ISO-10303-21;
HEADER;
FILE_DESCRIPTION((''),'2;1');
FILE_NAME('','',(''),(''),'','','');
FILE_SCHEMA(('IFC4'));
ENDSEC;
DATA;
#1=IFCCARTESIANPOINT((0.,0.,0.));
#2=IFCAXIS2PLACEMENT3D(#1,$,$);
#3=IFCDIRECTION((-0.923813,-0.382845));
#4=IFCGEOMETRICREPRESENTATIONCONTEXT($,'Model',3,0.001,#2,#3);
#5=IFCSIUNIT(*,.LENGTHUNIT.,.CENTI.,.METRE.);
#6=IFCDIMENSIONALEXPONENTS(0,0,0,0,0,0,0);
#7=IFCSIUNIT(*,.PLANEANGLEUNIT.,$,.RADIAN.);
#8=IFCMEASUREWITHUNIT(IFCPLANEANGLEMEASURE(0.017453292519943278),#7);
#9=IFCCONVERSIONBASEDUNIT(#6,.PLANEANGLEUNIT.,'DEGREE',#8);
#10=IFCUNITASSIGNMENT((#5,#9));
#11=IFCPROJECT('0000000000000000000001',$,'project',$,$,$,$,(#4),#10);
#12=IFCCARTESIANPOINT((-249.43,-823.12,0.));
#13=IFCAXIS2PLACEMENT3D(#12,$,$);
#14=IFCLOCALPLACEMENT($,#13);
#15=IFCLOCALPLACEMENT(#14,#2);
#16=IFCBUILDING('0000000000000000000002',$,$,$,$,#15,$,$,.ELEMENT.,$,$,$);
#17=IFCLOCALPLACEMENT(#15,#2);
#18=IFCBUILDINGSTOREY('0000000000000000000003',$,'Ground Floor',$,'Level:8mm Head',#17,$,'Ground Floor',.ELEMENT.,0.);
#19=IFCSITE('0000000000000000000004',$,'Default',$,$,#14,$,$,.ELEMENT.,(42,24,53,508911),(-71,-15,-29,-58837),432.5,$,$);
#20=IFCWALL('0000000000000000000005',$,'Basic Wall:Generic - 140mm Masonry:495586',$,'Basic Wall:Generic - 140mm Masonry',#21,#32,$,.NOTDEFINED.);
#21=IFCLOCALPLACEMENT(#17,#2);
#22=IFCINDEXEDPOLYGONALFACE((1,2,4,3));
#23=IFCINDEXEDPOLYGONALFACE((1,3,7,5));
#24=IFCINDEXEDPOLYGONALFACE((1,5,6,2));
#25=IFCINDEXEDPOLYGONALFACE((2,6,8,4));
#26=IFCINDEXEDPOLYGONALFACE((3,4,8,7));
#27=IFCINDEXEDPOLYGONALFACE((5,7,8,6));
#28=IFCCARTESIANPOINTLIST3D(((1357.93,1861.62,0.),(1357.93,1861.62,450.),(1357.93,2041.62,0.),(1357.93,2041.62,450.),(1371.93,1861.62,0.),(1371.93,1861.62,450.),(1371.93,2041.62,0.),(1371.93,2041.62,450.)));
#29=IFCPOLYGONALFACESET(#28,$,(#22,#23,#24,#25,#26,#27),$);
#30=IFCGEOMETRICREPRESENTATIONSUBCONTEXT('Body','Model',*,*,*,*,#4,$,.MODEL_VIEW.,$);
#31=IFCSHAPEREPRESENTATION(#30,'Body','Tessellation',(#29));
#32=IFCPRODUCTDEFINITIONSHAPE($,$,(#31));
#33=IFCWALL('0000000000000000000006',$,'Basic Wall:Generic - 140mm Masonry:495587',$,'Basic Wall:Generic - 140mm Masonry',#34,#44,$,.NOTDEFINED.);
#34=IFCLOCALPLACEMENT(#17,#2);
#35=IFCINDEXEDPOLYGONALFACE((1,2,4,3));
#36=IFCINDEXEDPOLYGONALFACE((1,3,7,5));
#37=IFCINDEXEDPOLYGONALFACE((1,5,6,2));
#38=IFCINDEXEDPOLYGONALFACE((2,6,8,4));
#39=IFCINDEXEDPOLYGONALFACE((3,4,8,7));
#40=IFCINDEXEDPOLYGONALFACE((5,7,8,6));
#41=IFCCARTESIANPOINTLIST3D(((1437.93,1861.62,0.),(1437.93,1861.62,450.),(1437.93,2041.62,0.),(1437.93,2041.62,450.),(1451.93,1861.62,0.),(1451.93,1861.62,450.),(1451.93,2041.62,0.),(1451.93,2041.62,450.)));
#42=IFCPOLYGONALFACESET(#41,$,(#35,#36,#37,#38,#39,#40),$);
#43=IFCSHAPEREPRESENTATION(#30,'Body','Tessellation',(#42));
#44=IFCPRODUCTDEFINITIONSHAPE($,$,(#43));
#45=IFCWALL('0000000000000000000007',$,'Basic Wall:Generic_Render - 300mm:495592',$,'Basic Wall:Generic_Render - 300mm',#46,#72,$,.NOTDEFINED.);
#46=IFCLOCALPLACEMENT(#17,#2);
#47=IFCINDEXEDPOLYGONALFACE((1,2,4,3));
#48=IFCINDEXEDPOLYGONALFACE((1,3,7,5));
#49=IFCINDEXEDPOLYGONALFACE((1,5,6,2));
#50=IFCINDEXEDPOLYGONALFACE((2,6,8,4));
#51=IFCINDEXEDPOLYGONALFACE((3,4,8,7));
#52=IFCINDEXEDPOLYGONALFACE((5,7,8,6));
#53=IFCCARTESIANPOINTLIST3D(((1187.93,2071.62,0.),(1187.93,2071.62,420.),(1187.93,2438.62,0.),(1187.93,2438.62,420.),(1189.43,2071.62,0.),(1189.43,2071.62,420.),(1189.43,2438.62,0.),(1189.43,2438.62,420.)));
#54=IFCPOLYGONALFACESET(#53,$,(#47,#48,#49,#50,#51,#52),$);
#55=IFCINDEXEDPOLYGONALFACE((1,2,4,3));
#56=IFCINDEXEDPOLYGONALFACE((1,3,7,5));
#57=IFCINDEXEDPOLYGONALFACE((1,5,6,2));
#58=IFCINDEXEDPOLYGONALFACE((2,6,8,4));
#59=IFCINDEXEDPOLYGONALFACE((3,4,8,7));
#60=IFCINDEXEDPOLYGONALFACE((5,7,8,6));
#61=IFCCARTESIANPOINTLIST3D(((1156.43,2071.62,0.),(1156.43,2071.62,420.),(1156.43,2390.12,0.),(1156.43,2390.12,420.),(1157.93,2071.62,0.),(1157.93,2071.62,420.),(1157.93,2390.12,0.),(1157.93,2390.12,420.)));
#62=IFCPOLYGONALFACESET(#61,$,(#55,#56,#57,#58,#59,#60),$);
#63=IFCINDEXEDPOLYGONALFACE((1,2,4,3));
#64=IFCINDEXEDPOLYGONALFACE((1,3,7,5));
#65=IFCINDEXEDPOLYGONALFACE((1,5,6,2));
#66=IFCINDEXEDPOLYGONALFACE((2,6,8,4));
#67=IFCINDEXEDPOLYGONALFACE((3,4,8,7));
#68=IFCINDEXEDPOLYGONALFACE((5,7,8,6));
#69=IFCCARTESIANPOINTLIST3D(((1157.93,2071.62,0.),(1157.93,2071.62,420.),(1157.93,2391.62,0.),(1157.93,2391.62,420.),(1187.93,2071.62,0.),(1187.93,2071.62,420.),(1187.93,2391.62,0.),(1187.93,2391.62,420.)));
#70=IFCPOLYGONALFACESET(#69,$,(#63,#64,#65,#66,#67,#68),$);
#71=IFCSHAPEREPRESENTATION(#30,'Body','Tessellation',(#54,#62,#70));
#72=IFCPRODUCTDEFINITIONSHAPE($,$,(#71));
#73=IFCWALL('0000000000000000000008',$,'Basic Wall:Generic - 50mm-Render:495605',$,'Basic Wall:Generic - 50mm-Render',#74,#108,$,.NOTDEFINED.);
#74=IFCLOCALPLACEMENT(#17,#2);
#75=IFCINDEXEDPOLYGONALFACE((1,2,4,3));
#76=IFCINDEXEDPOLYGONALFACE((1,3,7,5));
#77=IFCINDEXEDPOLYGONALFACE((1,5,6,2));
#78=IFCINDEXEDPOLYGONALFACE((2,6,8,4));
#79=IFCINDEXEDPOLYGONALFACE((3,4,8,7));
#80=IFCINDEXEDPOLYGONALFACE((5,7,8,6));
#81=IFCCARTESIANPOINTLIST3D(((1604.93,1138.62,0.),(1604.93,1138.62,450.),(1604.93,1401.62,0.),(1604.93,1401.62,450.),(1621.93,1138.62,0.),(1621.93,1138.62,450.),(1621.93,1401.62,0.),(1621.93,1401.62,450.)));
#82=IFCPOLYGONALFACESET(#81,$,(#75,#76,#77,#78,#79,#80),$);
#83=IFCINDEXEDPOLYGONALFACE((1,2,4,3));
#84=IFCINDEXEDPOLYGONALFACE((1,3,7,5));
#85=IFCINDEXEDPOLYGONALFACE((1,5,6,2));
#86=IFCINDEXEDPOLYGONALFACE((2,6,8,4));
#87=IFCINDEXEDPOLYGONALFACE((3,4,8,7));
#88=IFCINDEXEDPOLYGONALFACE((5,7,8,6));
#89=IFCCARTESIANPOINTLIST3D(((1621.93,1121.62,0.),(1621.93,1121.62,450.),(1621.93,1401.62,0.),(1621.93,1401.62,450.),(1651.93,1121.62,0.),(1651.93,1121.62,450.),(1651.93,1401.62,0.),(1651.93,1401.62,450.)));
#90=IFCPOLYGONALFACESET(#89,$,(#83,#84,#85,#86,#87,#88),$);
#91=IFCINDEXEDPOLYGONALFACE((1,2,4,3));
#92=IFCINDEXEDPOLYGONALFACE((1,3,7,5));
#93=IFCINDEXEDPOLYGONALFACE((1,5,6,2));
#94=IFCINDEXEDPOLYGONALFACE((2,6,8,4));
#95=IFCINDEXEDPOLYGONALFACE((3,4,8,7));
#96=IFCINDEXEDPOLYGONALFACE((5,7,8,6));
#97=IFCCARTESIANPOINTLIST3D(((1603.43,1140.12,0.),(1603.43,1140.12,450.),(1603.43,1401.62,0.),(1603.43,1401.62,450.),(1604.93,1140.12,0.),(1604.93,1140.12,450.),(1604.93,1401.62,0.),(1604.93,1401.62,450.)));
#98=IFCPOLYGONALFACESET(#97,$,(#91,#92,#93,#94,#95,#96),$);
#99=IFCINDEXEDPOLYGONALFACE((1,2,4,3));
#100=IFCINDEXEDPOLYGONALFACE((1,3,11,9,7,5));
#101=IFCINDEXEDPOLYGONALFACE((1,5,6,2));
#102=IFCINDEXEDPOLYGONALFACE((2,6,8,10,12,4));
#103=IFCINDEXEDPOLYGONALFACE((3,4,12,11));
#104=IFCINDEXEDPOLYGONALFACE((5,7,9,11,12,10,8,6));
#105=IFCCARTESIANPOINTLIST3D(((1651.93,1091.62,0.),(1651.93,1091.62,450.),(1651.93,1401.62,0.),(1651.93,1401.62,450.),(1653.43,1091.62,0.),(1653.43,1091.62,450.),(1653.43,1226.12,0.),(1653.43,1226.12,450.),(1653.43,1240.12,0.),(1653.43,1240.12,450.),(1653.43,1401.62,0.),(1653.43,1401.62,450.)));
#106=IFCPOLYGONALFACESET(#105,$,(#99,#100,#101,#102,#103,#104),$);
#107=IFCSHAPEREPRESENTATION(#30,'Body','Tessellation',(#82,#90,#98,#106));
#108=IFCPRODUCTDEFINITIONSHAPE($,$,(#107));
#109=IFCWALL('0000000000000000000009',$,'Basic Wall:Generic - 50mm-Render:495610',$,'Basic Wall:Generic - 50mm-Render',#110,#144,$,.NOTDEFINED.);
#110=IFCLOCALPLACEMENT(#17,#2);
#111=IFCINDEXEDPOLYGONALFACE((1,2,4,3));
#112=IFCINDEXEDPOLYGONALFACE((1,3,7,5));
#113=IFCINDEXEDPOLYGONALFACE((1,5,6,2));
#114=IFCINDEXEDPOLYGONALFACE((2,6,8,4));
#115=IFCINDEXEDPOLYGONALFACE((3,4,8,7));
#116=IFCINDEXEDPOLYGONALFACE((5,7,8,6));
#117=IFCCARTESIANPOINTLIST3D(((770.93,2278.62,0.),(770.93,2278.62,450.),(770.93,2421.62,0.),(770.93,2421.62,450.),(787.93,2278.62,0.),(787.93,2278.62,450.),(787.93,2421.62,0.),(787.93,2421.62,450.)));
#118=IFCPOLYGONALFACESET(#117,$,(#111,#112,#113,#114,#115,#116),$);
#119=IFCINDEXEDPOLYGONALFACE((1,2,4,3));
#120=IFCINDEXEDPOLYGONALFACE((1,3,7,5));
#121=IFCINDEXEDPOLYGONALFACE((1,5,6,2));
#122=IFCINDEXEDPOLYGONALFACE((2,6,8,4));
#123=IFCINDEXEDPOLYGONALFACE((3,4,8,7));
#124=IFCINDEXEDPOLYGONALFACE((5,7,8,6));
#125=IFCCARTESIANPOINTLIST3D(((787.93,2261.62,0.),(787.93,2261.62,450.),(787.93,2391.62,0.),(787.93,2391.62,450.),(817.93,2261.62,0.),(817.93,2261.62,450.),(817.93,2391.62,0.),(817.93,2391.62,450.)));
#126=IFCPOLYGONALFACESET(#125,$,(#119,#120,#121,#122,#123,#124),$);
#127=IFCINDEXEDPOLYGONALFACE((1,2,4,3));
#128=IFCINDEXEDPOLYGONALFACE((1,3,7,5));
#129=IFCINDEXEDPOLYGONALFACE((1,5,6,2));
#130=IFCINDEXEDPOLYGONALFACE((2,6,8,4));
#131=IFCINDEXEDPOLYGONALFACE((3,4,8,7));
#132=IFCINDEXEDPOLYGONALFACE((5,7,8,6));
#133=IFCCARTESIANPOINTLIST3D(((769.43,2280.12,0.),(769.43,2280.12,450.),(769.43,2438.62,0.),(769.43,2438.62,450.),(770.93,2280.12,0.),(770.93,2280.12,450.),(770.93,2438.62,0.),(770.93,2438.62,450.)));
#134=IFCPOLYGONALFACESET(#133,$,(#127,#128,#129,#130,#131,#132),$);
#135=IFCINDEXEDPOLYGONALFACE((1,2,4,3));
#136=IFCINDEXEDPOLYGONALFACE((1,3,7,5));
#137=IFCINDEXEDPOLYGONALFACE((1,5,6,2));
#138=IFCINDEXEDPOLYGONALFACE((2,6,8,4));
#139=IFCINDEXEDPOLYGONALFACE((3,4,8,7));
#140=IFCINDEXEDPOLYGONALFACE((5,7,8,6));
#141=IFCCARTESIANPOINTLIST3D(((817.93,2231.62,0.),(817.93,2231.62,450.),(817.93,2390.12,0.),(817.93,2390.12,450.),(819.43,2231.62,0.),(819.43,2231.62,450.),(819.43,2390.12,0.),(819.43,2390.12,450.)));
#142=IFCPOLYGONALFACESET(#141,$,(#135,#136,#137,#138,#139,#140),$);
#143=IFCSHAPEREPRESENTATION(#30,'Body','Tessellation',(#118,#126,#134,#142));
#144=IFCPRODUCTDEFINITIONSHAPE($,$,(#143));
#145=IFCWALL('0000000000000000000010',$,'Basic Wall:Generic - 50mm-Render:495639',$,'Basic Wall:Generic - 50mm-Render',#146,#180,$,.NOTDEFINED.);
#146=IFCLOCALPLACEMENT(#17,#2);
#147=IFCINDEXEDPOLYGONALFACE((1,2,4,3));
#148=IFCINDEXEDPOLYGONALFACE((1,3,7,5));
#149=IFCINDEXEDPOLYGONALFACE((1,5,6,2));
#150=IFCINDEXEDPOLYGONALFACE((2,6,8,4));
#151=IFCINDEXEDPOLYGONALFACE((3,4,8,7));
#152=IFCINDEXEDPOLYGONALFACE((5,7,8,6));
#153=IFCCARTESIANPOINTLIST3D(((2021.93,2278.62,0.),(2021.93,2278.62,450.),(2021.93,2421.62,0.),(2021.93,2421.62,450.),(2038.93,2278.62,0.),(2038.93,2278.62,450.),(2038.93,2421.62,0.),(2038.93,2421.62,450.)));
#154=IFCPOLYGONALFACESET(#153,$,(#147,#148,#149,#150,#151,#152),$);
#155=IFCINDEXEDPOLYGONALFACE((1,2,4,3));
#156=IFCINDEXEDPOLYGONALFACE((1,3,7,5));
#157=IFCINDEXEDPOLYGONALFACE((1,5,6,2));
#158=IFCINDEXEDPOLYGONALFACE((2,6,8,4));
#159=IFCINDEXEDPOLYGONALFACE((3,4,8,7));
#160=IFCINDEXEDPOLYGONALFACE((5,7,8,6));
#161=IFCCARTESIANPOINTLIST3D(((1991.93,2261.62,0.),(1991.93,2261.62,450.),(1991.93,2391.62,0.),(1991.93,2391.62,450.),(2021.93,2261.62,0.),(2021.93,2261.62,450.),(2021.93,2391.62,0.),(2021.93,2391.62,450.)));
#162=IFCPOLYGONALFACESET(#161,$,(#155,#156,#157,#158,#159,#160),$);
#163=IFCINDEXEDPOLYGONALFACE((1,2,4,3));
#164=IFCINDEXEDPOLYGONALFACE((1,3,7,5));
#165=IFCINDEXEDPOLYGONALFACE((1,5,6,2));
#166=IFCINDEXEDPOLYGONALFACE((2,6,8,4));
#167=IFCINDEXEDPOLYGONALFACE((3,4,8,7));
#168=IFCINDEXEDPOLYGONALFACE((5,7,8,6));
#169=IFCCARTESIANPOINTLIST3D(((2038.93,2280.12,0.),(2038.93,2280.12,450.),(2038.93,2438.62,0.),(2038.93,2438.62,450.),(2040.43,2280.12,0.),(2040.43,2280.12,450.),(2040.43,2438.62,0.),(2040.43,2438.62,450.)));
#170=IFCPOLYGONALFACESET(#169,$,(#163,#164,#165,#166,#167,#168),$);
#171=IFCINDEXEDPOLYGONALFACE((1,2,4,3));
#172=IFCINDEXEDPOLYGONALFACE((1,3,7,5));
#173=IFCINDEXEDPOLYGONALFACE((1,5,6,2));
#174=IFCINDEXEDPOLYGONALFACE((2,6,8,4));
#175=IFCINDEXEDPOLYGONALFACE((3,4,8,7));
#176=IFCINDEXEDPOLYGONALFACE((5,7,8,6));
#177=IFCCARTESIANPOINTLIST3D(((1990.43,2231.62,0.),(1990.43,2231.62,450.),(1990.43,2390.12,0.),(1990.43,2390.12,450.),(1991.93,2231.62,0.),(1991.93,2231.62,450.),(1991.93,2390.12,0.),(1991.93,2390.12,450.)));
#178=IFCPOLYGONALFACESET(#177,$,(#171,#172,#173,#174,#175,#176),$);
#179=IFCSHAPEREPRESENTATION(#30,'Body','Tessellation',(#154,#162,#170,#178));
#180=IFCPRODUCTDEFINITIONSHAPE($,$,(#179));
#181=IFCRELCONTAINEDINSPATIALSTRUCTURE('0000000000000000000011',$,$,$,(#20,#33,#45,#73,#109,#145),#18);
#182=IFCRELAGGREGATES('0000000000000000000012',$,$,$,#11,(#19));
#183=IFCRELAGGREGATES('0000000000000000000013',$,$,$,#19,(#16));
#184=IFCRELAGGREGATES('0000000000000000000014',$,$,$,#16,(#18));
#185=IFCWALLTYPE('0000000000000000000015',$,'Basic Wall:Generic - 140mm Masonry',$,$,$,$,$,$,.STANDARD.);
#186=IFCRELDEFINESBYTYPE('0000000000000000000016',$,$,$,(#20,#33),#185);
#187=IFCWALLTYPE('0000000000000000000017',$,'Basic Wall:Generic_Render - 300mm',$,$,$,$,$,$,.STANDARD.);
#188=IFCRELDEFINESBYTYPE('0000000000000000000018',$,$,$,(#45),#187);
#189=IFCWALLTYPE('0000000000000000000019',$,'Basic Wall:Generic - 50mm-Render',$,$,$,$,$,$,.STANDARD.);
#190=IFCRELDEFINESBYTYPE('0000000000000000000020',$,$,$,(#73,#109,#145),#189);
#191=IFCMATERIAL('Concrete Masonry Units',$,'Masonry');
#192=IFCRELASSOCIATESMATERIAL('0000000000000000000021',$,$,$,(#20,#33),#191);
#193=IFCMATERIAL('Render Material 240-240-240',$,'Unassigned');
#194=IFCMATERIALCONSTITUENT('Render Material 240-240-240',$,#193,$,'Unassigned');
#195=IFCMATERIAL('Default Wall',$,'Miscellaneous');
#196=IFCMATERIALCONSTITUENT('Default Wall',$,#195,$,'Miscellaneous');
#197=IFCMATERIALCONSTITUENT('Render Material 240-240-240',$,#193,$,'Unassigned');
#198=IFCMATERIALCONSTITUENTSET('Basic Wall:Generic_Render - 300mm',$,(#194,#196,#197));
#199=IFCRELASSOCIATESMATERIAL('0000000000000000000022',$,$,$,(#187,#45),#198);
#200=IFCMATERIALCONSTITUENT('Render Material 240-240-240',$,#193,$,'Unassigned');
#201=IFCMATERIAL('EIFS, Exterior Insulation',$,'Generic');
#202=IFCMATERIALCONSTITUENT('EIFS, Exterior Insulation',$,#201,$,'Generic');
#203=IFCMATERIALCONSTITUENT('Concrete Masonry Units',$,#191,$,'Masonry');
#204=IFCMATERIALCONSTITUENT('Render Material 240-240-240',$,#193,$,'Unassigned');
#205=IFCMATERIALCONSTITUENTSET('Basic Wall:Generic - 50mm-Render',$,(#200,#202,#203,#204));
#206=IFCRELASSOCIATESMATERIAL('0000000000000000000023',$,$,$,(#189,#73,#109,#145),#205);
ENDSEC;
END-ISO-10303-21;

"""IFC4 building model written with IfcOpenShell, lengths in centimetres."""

from ifc_helpers import new_model, entity, si_unit, converted_unit, direction, frame, origin, place, context, subcontext, project, spatial, indexed_curve, outline, extrude, material, constituent, constituent_set, type_object, element, save


model = new_model("IFC4")

# Units and contexts
model_context = context("Model", 3, precision=0.001, world=origin(), true_north=direction((-0.923813, -0.382845)))
body_context = subcontext(model_context, "Body", "Model", "MODEL_VIEW")
ifc_project = project(units=[si_unit("LENGTHUNIT", "METRE", prefix="CENTI"), converted_unit("PLANEANGLEUNIT", "DEGREE", entity("IfcPlaneAngleMeasure", 0.017453292519943278), si_unit("PLANEANGLEUNIT", "RADIAN"), dimensions=[0, 0, 0, 0, 0, 0, 0])], contexts=[model_context])

# Site, building, storey
site_placement = place(None, frame((-249.43, -823.12, 0.0)))
site = spatial("IfcSite", under=ifc_project, at=site_placement, Name="Default", CompositionType="ELEMENT", RefLatitude=(42, 24, 53, 508911), RefLongitude=(-71, -15, -29, -58837), RefElevation=432.5)
building_placement = place(site_placement, origin())
building = spatial("IfcBuilding", under=site, at=building_placement, CompositionType="ELEMENT")
storey_placement = place(building_placement, origin())
storey = spatial("IfcBuildingStorey", under=building, at=storey_placement, Name="Ground Floor", ObjectType="Level:8mm Head", LongName="Ground Floor", CompositionType="ELEMENT", Elevation=0.0)

# Walls
ifc_material_1 = material(Name="Concrete Masonry Units", Category="Masonry")
wall_type_1 = type_object("IfcWallType", Name="Basic Wall:Generic - 140mm Masonry", PredefinedType="STANDARD")
wall_1_placement = place(storey_placement, frame((1364.93, 2041.62, 0.0), z_axis=(0.0, 0.0, 1.0), x_axis=(0.0, -1.0, 0.0)))
element("IfcWall", 1, at=wall_1_placement, inside=storey, type_object=wall_type_1, material=ifc_material_1, Name="Basic Wall:Generic - 140mm Masonry:495586", ObjectType="Basic Wall:Generic - 140mm Masonry", PredefinedType="NOTDEFINED", context=body_context, shape_type="SweptSolid", body=[
    extrude(outline(indexed_curve([(180.0, 7.0), (0.0, 7.0), (0.0, -7.0), (180.0, -7.0), (180.0, 7.0)], self_intersect=False)), origin(), (0.0, 0.0, 1.0), 450.0),
])
wall_2_placement = place(storey_placement, frame((1444.93, 2041.62, 0.0), z_axis=(0.0, 0.0, 1.0), x_axis=(0.0, -1.0, 0.0)))
element("IfcWall", 2, at=wall_2_placement, inside=storey, type_object=wall_type_1, material=ifc_material_1, Name="Basic Wall:Generic - 140mm Masonry:495587", ObjectType="Basic Wall:Generic - 140mm Masonry", PredefinedType="NOTDEFINED", context=body_context, shape_type="SweptSolid", body=[
    extrude(outline(indexed_curve([(180.0, 7.0), (0.0, 7.0), (0.0, -7.0), (180.0, -7.0), (180.0, 7.0)], self_intersect=False)), origin(), (0.0, 0.0, 1.0), 450.0),
])
ifc_material_2 = material(Name="Render Material 240-240-240", Category="Unassigned")
ifc_constituent_1 = constituent(ifc_material_2, Name="Render Material 240-240-240", Category="Unassigned")
ifc_material_3 = material(Name="Default Wall", Category="Miscellaneous")
ifc_constituent_2 = constituent(ifc_material_3, Name="Default Wall", Category="Miscellaneous")
ifc_constituent_3 = constituent(ifc_material_2, Name="Render Material 240-240-240", Category="Unassigned")
ifc_constituent_set_1 = constituent_set(constituents=[ifc_constituent_1, ifc_constituent_2, ifc_constituent_3], Name="Basic Wall:Generic_Render - 300mm")
wall_type_2 = type_object("IfcWallType", Name="Basic Wall:Generic_Render - 300mm", PredefinedType="STANDARD", material=ifc_constituent_set_1)
wall_3_placement = place(storey_placement, frame((1172.93, 2071.62, 0.0), z_axis=(0.0, 0.0, 1.0), x_axis=(0.0, 1.0, 0.0)))
element("IfcWall", 3, at=wall_3_placement, inside=storey, type_object=wall_type_2, material=ifc_constituent_set_1, Name="Basic Wall:Generic_Render - 300mm:495592", ObjectType="Basic Wall:Generic_Render - 300mm", PredefinedType="NOTDEFINED", context=body_context, shape_type="SweptSolid", body=[
    extrude(outline(indexed_curve([(-0.75, -183.5), (0.75, -183.5), (0.75, 183.5), (-0.75, 183.5), (-0.75, -183.5)], self_intersect=False)), frame((183.5, -15.75, 0.0), z_axis=(0.0, 0.0, 1.0), x_axis=(0.0, 1.0, 0.0)), (0.0, 0.0, 1.0), 420.0),
    extrude(outline(indexed_curve([(-0.75, -159.25), (0.75, -159.25), (0.75, 159.25), (-0.75, 159.25), (-0.75, -159.25)], self_intersect=False)), frame((159.25, 15.75, 0.0), z_axis=(0.0, 0.0, 1.0), x_axis=(0.0, -1.0, 0.0)), (0.0, 0.0, 1.0), 420.0),
    extrude(outline(indexed_curve([(-160.0, -15.0), (160.0, -15.0), (160.0, 15.0), (-160.0, 15.0), (-160.0, -15.0)], self_intersect=False)), frame((160.0, 0.0, 0.0)), (0.0, 0.0, 1.0), 420.0),
])
ifc_constituent_4 = constituent(ifc_material_2, Name="Render Material 240-240-240", Category="Unassigned")
ifc_material_4 = material(Name="EIFS, Exterior Insulation", Category="Generic")
ifc_constituent_5 = constituent(ifc_material_4, Name="EIFS, Exterior Insulation", Category="Generic")
ifc_constituent_6 = constituent(ifc_material_1, Name="Concrete Masonry Units", Category="Masonry")
ifc_constituent_7 = constituent(ifc_material_2, Name="Render Material 240-240-240", Category="Unassigned")
ifc_constituent_set_2 = constituent_set(constituents=[ifc_constituent_4, ifc_constituent_5, ifc_constituent_6, ifc_constituent_7], Name="Basic Wall:Generic - 50mm-Render")
wall_type_3 = type_object("IfcWallType", Name="Basic Wall:Generic - 50mm-Render", PredefinedType="STANDARD", material=ifc_constituent_set_2)
wall_4_placement = place(storey_placement, frame((1628.43, 1401.62, 0.0), z_axis=(0.0, 0.0, 1.0), x_axis=(0.0, -1.0, 0.0)))
element("IfcWall", 4, at=wall_4_placement, inside=storey, type_object=wall_type_3, material=ifc_constituent_set_2, Name="Basic Wall:Generic - 50mm-Render:495605", ObjectType="Basic Wall:Generic - 50mm-Render", PredefinedType="NOTDEFINED", context=body_context, shape_type="SweptSolid", body=[
    extrude(outline(indexed_curve([(-131.5, -8.5), (131.5, -8.5), (131.5, 8.5), (-131.5, 8.5), (-131.5, -8.5)], self_intersect=False)), frame((131.5, -15.0, 0.0)), (0.0, 0.0, 1.0), 450.0),
    extrude(outline(indexed_curve([(-140.0, -15.0), (140.0, -15.0), (140.0, 15.0), (-140.0, 15.0), (-140.0, -15.0)], self_intersect=False)), frame((140.0, 8.5, 0.0)), (0.0, 0.0, 1.0), 450.0),
    extrude(outline(indexed_curve([(-0.75, -130.75), (0.75, -130.75), (0.75, 130.75), (-0.75, 130.75), (-0.75, -130.75)], self_intersect=False)), frame((130.75, -24.25, 0.0), z_axis=(0.0, 0.0, 1.0), x_axis=(0.0, 1.0, 0.0)), (0.0, 0.0, 1.0), 450.0),
    extrude(outline(indexed_curve([(-16.0, -0.5), (-2.0, -0.5), (159.5, -0.5), (159.5, 1.0), (-150.5, 1.0), (-150.5, -0.5), (-16.0, -0.5)], self_intersect=False)), frame((159.5, 24.5, 0.0), z_axis=(0.0, 0.0, 1.0), x_axis=(-1.0, 0.0, 0.0)), (0.0, 0.0, 1.0), 450.0),
])
wall_5_placement = place(storey_placement, frame((794.43, 2280.12, 0.0), z_axis=(0.0, 0.0, 1.0), x_axis=(0.0, 1.0, 0.0)))
element("IfcWall", 5, at=wall_5_placement, inside=storey, type_object=wall_type_3, material=ifc_constituent_set_2, Name="Basic Wall:Generic - 50mm-Render:495610", ObjectType="Basic Wall:Generic - 50mm-Render", PredefinedType="NOTDEFINED", context=body_context, shape_type="SweptSolid", body=[
    extrude(outline(indexed_curve([(-71.5, -8.5), (71.5, -8.5), (71.5, 8.5), (-71.5, 8.5), (-71.5, -8.5)], self_intersect=False)), frame((70.0, 15.0, 0.0)), (0.0, 0.0, 1.0), 450.0),
    extrude(outline(indexed_curve([(-65.0, -15.0), (65.0, -15.0), (65.0, 15.0), (-65.0, 15.0), (-65.0, -15.0)], self_intersect=False)), frame((46.5, -8.5, 0.0)), (0.0, 0.0, 1.0), 450.0),
    extrude(outline(indexed_curve([(-0.75, -79.25), (0.75, -79.25), (0.75, 79.25), (-0.75, 79.25), (-0.75, -79.25)], self_intersect=False)), frame((79.25, 24.25, 0.0), z_axis=(0.0, 0.0, 1.0), x_axis=(0.0, -1.0, 0.0)), (0.0, 0.0, 1.0), 450.0),
    extrude(outline(indexed_curve([(-0.75, -79.25), (0.75, -79.25), (0.75, 79.25), (-0.75, 79.25), (-0.75, -79.25)], self_intersect=False)), frame((30.75, -24.25, 0.0), z_axis=(0.0, 0.0, 1.0), x_axis=(0.0, 1.0, 0.0)), (0.0, 0.0, 1.0), 450.0),
])
wall_6_placement = place(storey_placement, frame((2015.43, 2280.12, 0.0), z_axis=(0.0, 0.0, 1.0), x_axis=(0.0, 1.0, 0.0)))
element("IfcWall", 6, at=wall_6_placement, inside=storey, type_object=wall_type_3, material=ifc_constituent_set_2, Name="Basic Wall:Generic - 50mm-Render:495639", ObjectType="Basic Wall:Generic - 50mm-Render", PredefinedType="NOTDEFINED", context=body_context, shape_type="SweptSolid", body=[
    extrude(outline(indexed_curve([(-71.5, -8.5), (71.5, -8.5), (71.5, 8.5), (-71.5, 8.5), (-71.5, -8.5)], self_intersect=False)), frame((70.0, -15.0, 0.0)), (0.0, 0.0, 1.0), 450.0),
    extrude(outline(indexed_curve([(-65.0, -15.0), (65.0, -15.0), (65.0, 15.0), (-65.0, 15.0), (-65.0, -15.0)], self_intersect=False)), frame((46.5, 8.5, 0.0)), (0.0, 0.0, 1.0), 450.0),
    extrude(outline(indexed_curve([(-0.75, -79.25), (0.75, -79.25), (0.75, 79.25), (-0.75, 79.25), (-0.75, -79.25)], self_intersect=False)), frame((79.25, -24.25, 0.0), z_axis=(0.0, 0.0, 1.0), x_axis=(0.0, 1.0, 0.0)), (0.0, 0.0, 1.0), 450.0),
    extrude(outline(indexed_curve([(-0.75, -79.25), (0.75, -79.25), (0.75, 79.25), (-0.75, 79.25), (-0.75, -79.25)], self_intersect=False)), frame((30.75, 24.25, 0.0), z_axis=(0.0, 0.0, 1.0), x_axis=(0.0, -1.0, 0.0)), (0.0, 0.0, 1.0), 450.0),
])

save(model, "model.ifc")
